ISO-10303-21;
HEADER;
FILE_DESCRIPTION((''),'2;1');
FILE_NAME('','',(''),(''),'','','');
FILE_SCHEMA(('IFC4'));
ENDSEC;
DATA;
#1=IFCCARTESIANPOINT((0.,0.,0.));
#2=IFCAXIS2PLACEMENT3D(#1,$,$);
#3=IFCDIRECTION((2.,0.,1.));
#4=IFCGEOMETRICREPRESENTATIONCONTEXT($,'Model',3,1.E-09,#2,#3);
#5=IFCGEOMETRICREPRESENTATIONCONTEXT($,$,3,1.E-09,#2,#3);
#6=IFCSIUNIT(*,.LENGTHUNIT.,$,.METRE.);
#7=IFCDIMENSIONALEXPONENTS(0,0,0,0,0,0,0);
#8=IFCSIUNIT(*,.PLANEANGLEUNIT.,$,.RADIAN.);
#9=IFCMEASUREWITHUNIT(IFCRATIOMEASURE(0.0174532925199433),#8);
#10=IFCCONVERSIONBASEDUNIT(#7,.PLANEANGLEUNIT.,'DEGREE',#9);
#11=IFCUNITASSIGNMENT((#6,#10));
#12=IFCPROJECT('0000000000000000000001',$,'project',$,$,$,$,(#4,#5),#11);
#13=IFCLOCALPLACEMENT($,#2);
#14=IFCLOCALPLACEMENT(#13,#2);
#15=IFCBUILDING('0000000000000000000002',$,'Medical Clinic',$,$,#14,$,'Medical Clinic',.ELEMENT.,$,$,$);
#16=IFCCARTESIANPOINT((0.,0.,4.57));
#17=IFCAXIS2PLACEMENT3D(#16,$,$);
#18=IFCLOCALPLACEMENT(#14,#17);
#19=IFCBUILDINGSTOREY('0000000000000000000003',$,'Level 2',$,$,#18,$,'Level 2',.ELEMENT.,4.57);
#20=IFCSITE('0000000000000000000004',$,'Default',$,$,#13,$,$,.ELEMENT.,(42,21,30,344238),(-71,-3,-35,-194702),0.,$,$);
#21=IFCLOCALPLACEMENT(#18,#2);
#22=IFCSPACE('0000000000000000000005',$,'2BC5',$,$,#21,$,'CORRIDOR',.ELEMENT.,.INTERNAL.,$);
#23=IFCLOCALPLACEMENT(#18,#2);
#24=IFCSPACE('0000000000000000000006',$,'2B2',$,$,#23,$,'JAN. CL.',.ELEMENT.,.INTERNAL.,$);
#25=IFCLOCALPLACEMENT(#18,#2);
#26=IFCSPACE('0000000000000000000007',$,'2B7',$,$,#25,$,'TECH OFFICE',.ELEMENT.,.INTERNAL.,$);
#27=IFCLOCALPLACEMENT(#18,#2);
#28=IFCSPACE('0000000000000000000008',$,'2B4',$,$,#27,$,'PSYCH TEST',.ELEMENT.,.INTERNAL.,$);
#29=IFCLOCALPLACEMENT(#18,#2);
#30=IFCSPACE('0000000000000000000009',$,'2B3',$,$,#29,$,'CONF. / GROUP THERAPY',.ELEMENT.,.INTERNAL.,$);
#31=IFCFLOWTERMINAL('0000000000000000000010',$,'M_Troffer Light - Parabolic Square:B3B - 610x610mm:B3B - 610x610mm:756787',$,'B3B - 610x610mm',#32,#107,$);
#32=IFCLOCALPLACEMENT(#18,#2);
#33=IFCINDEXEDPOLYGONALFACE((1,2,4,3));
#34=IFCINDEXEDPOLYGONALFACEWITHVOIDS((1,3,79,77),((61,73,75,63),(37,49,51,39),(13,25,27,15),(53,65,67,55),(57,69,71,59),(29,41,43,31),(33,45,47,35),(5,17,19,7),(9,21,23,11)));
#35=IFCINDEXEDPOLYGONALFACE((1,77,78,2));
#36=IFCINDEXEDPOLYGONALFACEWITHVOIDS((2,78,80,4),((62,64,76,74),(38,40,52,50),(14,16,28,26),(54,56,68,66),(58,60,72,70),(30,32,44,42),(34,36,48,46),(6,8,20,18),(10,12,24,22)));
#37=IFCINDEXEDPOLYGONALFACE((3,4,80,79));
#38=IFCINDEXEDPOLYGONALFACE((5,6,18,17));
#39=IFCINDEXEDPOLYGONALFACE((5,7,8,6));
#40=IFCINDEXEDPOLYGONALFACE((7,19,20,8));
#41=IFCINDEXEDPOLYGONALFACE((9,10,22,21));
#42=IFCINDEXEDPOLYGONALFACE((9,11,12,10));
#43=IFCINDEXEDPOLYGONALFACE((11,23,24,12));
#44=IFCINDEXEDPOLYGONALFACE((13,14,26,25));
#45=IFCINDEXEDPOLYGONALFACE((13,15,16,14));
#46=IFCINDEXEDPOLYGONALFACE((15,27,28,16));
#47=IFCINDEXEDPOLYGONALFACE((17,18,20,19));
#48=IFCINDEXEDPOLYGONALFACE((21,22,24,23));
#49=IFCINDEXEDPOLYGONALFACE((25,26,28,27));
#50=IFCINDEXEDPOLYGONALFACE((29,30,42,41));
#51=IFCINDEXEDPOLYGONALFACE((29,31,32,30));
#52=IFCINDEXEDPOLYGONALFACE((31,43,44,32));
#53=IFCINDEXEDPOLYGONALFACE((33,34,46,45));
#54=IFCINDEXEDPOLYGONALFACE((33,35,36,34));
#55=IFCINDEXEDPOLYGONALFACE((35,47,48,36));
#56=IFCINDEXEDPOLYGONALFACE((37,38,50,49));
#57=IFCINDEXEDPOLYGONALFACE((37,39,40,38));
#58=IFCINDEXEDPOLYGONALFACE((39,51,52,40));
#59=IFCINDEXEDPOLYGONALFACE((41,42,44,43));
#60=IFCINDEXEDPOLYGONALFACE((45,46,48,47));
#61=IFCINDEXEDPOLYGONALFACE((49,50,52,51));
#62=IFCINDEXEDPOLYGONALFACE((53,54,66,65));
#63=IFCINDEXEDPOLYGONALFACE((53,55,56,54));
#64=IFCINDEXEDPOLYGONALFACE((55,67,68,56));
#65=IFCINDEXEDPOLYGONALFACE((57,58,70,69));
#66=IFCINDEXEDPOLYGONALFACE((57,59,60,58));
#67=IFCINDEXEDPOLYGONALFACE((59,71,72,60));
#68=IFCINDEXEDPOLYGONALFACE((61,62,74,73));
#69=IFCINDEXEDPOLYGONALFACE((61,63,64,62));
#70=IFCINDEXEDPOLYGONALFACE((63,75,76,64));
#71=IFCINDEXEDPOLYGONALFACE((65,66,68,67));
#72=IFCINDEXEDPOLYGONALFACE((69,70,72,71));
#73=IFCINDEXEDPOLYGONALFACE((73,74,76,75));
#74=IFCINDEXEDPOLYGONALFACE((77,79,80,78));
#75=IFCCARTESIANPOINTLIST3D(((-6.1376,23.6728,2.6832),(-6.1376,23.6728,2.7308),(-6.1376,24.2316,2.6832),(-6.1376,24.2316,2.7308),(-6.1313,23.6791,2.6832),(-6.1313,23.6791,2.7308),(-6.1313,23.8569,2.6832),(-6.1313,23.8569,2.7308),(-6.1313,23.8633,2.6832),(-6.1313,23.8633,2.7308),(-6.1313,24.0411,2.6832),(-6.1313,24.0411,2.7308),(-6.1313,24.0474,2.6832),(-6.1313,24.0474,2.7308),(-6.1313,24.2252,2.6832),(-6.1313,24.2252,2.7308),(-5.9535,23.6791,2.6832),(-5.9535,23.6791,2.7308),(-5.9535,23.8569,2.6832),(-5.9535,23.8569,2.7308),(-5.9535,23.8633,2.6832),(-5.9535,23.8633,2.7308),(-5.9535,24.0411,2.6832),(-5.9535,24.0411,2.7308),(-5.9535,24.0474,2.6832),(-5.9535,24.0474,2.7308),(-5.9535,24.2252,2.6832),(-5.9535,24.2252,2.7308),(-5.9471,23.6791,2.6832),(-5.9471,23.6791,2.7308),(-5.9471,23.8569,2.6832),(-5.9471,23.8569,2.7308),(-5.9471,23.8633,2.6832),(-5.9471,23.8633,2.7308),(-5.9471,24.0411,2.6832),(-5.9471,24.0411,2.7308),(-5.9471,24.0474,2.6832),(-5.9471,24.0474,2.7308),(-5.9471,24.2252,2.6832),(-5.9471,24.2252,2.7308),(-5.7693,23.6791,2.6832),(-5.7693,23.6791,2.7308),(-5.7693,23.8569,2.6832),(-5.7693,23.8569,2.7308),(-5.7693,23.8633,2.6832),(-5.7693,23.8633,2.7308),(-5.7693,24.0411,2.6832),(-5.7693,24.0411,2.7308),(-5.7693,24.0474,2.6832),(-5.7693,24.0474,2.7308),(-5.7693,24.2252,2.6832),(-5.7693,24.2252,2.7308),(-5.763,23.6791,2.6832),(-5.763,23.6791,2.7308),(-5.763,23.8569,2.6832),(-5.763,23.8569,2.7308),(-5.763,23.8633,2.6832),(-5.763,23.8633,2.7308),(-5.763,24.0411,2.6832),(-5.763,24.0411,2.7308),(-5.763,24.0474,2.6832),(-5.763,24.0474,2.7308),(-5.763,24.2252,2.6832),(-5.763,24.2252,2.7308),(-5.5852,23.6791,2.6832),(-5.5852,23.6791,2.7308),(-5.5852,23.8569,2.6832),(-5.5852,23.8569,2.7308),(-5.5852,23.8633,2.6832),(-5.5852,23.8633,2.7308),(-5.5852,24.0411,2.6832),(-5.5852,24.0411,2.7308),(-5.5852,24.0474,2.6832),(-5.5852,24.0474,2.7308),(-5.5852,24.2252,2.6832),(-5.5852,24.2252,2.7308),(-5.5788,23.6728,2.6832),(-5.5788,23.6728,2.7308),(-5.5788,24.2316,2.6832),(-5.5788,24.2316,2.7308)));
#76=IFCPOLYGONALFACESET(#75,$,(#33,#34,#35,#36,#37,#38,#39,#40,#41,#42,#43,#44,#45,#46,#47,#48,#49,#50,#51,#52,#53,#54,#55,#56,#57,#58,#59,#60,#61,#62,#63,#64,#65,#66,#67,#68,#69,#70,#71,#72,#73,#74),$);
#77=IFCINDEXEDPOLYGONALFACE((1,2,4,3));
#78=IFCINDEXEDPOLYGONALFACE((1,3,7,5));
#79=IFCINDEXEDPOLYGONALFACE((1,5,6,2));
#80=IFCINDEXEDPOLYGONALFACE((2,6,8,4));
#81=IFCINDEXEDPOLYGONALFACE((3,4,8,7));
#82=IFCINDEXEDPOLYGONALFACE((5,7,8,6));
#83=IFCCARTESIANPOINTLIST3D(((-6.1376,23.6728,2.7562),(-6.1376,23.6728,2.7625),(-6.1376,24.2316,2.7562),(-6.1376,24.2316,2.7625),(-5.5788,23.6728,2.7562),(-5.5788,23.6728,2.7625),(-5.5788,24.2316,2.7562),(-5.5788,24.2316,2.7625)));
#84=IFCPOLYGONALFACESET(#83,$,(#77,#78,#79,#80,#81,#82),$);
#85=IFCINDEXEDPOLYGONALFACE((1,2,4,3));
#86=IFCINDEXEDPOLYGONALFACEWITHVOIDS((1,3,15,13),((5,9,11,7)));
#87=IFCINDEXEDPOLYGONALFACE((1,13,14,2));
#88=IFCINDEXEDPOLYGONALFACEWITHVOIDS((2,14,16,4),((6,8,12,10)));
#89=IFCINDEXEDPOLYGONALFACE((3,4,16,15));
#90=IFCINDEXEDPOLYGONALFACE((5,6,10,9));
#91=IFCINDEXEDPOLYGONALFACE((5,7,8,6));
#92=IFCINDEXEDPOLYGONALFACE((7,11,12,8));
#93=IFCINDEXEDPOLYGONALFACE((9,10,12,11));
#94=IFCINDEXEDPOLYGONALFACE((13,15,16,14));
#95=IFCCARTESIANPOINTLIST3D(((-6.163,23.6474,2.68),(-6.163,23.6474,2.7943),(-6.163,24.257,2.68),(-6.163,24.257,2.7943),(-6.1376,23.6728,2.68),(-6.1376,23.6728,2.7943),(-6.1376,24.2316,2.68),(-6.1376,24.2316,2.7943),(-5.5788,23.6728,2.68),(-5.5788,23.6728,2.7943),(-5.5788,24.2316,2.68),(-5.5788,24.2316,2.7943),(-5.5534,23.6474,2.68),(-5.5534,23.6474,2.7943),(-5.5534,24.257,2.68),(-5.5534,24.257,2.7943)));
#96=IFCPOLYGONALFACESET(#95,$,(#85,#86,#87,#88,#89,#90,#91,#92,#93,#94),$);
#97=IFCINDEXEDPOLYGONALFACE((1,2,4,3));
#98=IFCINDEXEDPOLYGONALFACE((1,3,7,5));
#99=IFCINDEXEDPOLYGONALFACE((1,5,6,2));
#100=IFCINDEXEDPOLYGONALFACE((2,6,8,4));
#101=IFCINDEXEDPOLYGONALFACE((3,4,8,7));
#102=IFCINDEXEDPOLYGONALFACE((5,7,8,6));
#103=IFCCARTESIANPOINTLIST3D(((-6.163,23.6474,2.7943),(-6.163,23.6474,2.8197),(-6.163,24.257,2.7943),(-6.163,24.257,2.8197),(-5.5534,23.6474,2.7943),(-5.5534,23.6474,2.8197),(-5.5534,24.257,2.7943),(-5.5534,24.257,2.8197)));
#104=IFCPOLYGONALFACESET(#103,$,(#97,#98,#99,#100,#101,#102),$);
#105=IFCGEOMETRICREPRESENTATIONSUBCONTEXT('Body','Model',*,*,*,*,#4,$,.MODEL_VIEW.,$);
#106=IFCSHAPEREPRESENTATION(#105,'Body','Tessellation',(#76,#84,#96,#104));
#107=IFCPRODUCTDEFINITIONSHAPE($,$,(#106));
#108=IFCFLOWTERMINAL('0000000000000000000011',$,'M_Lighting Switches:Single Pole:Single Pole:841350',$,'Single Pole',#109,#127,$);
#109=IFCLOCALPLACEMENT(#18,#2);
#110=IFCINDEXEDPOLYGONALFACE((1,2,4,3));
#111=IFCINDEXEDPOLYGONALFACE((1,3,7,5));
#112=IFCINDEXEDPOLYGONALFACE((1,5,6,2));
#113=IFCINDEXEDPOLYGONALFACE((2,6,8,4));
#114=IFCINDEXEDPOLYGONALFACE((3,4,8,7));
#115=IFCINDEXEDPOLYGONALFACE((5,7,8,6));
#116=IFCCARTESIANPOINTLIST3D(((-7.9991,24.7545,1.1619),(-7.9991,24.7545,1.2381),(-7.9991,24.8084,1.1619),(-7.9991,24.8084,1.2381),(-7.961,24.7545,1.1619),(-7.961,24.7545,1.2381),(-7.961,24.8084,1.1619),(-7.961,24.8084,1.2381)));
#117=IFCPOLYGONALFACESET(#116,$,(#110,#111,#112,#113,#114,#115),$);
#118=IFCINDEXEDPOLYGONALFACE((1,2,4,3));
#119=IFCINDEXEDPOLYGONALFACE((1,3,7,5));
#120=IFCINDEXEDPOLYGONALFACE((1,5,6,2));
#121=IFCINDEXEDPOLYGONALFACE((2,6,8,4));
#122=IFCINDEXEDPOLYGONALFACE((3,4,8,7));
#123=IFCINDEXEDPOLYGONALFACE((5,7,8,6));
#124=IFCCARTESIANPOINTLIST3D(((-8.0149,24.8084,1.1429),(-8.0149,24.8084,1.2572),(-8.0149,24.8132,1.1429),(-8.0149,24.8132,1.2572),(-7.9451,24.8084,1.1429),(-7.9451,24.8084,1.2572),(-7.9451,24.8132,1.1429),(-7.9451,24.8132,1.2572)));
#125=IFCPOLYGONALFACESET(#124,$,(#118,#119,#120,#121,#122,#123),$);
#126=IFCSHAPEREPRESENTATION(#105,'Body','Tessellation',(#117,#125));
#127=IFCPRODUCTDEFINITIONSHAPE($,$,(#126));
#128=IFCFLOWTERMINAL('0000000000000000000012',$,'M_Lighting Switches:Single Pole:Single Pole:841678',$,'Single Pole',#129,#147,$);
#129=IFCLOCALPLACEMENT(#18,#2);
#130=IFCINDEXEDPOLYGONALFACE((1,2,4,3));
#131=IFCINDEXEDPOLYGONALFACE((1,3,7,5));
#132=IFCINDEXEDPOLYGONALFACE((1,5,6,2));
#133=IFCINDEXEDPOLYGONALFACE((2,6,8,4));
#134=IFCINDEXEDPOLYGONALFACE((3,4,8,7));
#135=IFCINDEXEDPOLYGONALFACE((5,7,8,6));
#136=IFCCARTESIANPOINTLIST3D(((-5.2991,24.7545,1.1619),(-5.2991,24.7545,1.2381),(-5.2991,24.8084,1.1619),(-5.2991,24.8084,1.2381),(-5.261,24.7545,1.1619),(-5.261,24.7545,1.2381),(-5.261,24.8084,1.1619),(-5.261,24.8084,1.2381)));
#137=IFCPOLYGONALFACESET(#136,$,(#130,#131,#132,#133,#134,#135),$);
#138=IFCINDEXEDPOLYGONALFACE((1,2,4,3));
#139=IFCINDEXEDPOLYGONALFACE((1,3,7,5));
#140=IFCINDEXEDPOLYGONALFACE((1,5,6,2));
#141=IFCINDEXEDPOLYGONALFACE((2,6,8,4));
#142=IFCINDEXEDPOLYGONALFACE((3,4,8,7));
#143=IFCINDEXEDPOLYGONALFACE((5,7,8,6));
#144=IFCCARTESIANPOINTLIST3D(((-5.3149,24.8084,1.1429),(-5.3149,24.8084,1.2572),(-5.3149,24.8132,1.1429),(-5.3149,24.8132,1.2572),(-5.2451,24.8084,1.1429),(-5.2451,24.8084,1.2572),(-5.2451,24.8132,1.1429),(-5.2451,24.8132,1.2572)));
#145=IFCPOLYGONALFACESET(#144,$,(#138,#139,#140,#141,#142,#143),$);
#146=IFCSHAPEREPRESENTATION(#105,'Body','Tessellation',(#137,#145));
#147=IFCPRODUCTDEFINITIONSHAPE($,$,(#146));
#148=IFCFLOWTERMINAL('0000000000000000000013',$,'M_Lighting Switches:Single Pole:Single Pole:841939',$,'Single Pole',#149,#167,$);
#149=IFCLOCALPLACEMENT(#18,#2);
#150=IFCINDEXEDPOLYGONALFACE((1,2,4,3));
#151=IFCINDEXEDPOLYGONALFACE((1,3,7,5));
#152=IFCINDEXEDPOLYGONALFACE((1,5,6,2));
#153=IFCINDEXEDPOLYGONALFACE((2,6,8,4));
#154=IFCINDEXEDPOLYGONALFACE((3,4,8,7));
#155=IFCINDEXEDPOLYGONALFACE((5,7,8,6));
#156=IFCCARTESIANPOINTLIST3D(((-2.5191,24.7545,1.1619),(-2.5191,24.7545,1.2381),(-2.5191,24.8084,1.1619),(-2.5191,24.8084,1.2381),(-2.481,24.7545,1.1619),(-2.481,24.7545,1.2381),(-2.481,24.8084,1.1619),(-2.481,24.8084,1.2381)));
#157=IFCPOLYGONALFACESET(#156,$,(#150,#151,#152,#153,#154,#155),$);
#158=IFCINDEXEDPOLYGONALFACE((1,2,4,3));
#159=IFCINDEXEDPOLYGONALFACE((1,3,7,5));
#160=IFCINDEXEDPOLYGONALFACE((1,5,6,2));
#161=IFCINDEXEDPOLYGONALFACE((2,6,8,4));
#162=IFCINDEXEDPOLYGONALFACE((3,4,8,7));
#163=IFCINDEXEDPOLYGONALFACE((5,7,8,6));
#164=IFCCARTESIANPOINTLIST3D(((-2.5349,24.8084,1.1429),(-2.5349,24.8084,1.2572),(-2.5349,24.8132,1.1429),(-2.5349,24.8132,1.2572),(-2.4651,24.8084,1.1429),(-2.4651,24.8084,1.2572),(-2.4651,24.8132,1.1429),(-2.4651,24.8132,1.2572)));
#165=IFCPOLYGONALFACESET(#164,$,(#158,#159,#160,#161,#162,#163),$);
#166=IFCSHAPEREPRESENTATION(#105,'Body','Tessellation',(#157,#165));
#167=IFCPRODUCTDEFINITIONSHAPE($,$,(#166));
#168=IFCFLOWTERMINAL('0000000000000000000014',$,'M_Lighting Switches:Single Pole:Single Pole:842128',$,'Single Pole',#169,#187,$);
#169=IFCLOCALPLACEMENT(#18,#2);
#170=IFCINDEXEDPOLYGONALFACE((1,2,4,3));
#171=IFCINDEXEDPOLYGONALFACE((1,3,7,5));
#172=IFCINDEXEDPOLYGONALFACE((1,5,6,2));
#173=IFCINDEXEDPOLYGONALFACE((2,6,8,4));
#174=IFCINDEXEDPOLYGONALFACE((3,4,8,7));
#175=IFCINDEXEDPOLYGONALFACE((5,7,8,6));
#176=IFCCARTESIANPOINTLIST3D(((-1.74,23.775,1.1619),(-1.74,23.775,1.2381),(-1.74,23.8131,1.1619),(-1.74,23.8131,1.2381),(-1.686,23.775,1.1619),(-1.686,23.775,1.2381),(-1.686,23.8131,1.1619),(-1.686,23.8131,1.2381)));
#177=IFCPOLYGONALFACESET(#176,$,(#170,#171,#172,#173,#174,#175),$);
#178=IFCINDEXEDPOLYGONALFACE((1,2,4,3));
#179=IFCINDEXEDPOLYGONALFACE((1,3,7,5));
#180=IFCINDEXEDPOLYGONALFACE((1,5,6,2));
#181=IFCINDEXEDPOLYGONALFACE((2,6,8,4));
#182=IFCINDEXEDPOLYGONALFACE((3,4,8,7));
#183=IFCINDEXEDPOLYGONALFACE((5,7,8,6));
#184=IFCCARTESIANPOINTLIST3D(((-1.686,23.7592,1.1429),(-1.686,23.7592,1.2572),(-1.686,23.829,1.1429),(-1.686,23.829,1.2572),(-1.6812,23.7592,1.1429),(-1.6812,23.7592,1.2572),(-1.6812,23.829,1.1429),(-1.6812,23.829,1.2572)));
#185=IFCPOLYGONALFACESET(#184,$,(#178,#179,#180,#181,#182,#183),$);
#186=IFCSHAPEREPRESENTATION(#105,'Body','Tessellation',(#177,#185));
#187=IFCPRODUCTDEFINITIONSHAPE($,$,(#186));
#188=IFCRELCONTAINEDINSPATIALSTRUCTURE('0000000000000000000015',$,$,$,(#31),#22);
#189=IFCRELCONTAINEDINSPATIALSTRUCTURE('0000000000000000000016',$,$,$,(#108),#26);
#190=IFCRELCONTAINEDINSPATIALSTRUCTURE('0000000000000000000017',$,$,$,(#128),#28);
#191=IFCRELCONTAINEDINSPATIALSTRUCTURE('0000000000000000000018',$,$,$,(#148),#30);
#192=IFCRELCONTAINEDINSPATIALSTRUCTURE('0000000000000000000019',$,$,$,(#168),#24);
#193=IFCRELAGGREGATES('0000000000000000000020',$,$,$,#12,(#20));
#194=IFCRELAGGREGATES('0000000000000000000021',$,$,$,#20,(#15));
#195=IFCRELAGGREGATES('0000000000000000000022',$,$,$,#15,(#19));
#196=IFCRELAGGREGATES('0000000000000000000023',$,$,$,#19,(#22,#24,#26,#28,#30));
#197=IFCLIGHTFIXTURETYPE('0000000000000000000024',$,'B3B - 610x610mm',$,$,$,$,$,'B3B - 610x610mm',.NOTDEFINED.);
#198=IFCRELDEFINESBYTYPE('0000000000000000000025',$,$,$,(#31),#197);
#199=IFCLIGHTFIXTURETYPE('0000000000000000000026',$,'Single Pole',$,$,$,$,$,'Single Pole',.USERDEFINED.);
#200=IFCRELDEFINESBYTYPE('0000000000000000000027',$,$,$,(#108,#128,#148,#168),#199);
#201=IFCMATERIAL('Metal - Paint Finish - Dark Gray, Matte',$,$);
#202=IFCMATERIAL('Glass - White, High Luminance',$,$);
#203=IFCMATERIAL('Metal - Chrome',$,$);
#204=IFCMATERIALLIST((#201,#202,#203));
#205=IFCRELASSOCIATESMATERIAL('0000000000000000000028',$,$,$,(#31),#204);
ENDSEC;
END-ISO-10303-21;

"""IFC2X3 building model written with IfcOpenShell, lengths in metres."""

from ifc_helpers import new_model, entity, si_unit, converted_unit, direction, frame, frame_2d, origin, origin_2d_with_axis, place, context, subcontext, project, spatial, polyline, rectangle, outline, extrude, source, transform, mapped, material, material_list, type_object, type_shapes, element, save


model = new_model("IFC2X3")

# Units and contexts
model_context = context("Model", 3, precision=1e-09, world=origin(), true_north=direction((2.0, 0.0, 1.0)))
context_of_model = context(None, 3, precision=1e-09, world=origin(), true_north=direction((2.0, 0.0, 1.0)))
body_context = subcontext(model_context, "Body", "Model", "MODEL_VIEW")
ifc_project = project(units=[si_unit("LENGTHUNIT", "METRE"), converted_unit("PLANEANGLEUNIT", "DEGREE", entity("IfcRatioMeasure", 0.0174532925199433), si_unit("PLANEANGLEUNIT", "RADIAN"), dimensions=[0, 0, 0, 0, 0, 0, 0])], contexts=[model_context, context_of_model])

# Site, building, storey, space
site_placement = place(None, origin())
site = spatial("IfcSite", under=ifc_project, at=site_placement, Name="Default", CompositionType="ELEMENT", RefLatitude=(42, 21, 30, 344238), RefLongitude=(-71, -3, -35, -194702), RefElevation=0.0)
building_placement = place(site_placement, origin())
building = spatial("IfcBuilding", under=site, at=building_placement, Name="Medical Clinic", LongName="Medical Clinic", CompositionType="ELEMENT")
storey_placement = place(building_placement, frame((0.0, 0.0, 4.57)))
storey = spatial("IfcBuildingStorey", under=building, at=storey_placement, Name="Level 2", LongName="Level 2", CompositionType="ELEMENT", Elevation=4.57)
space_1_placement = place(storey_placement, origin())
space_1 = spatial("IfcSpace", under=storey, at=space_1_placement, Name="2BC5", LongName="CORRIDOR", CompositionType="ELEMENT", InteriorOrExteriorSpace="INTERNAL")

# Flow terminal
ifc_material_1 = material(Name="Metal - Paint Finish - Dark Gray, Matte")
ifc_material_2 = material(Name="Glass - White, High Luminance")
ifc_material_3 = material(Name="Metal - Chrome")
ifc_material_list_1 = material_list([ifc_material_1, ifc_material_2, ifc_material_3])
light_fixture_type_1 = type_object("IfcLightFixtureType", Name="B3B - 610x610mm", ElementType="B3B - 610x610mm", PredefinedType="NOTDEFINED")
shared_shape_1 = source(origin(), body_context, "Body", "SweptSolid", [
    extrude(outline(polyline([(-0.2794, -0.2794), (0.2794, -0.2794), (0.2794, 0.2794), (-0.2794, 0.2794), (-0.2794, -0.2794)]), holes=[polyline([(-0.0952, 0.0953), (-0.273, 0.0953), (-0.273, 0.2731), (-0.0952, 0.2731), (-0.0952, 0.0953)]), polyline([(0.2731, 0.0953), (0.0953, 0.0953), (0.0953, 0.2731), (0.2731, 0.2731), (0.2731, 0.0953)]), polyline([(-0.0889, 0.2731), (0.0889, 0.2731), (0.0889, 0.0953), (-0.0889, 0.0953), (-0.0889, 0.2731)]), polyline([(0.2731, -0.273), (0.0953, -0.273), (0.0953, -0.0952), (0.2731, -0.0952), (0.2731, -0.273)]), polyline([(0.0889, -0.273), (-0.0889, -0.273), (-0.0889, -0.0952), (0.0889, -0.0952), (0.0889, -0.273)]), polyline([(-0.0952, -0.273), (-0.273, -0.273), (-0.273, -0.0952), (-0.0952, -0.0952), (-0.0952, -0.273)]), polyline([(-0.0952, -0.0889), (-0.273, -0.0889), (-0.273, 0.0889), (-0.0952, 0.0889), (-0.0952, -0.0889)]), polyline([(0.0889, -0.0889), (-0.0889, -0.0889), (-0.0889, 0.0889), (0.0889, 0.0889), (0.0889, -0.0889)]), polyline([(0.2731, -0.0889), (0.0953, -0.0889), (0.0953, 0.0889), (0.2731, 0.0889), (0.2731, -0.0889)])]), frame((0.0, -0.3048, -0.0508), z_axis=(0.0, 0.0, 1.0), x_axis=(-1.0, 0.0, 0.0)), (0.0, 0.0, 1.0), 0.0476),
    extrude(rectangle(XDim=0.5588, YDim=0.5588, at=origin_2d_with_axis()), frame((0.0, -0.3048, -0.0825), z_axis=(0.0, 0.0, 1.0), x_axis=(-1.0, 0.0, 0.0)), (0.0, 0.0, 1.0), 0.0064),
    extrude(outline(polyline([(-0.3048, -0.3048), (0.3048, -0.3048), (0.3048, 0.3048), (-0.3048, 0.3048), (-0.3048, -0.3048)]), holes=[polyline([(0.2794, 0.2794), (0.2794, -0.2794), (-0.2794, -0.2794), (-0.2794, 0.2794), (0.2794, 0.2794)])]), frame((0.0, -0.3048, -0.1143)), (0.0, 0.0, 1.0), 0.1143),
    extrude(rectangle(XDim=0.6096, YDim=0.6096, at=origin_2d_with_axis()), frame((0.0, -0.3048, -0.1397), z_axis=(0.0, 0.0, 1.0), x_axis=(-1.0, 0.0, 0.0)), (0.0, 0.0, 1.0), 0.0254),
])
type_shapes(light_fixture_type_1, [shared_shape_1])
flow_terminal_1_placement = place(space_1_placement, frame((-5.8582, 23.6474, 2.68), z_axis=(0.0, 0.0, -1.0), x_axis=(1.0, 0.0, 0.0)))
element("IfcFlowTerminal", 1, at=flow_terminal_1_placement, inside=space_1, type_object=light_fixture_type_1, material=ifc_material_list_1, Name="M_Troffer Light - Parabolic Square:B3B - 610x610mm:B3B - 610x610mm:756787", ObjectType="B3B - 610x610mm", context=body_context, shape_type="MappedRepresentation", body=[
    mapped(shared_shape_1, transform((0.0, 0.0, 0.0), scale=1.0)),
])

# Shared definitions
space_2_placement = place(storey_placement, origin())
space_2 = spatial("IfcSpace", under=storey, at=space_2_placement, Name="2B2", LongName="JAN. CL.", CompositionType="ELEMENT", InteriorOrExteriorSpace="INTERNAL")

# Shared definitions
space_3_placement = place(storey_placement, origin())
space_3 = spatial("IfcSpace", under=storey, at=space_3_placement, Name="2B7", LongName="TECH OFFICE", CompositionType="ELEMENT", InteriorOrExteriorSpace="INTERNAL")

# Flow terminal
light_fixture_type_2 = type_object("IfcLightFixtureType", Name="Single Pole", ElementType="Single Pole", PredefinedType="USERDEFINED")
shared_shape_2 = source(origin(), body_context, "Body", "SweptSolid", [
    extrude(rectangle(XDim=0.0381, YDim=0.0762, at=origin_2d_with_axis()), frame((0.0, 0.0, -0.054), z_axis=(0.0, 0.0, 1.0), x_axis=(-1.0, 0.0, 0.0)), (0.0, 0.0, 1.0), 0.054),
    extrude(rectangle(XDim=0.0698, YDim=0.1143, at=frame_2d((0.0, 0.0), x_axis=(1.0, 0.0))), frame((0.0, 0.0, 0.0), z_axis=(0.0, 0.0, 1.0), x_axis=(-1.0, 0.0, 0.0)), (0.0, 0.0, 1.0), 0.0048),
])
type_shapes(light_fixture_type_2, [shared_shape_2])
flow_terminal_2_placement = place(space_3_placement, frame((-7.98, 24.8084, 1.2), z_axis=(0.0, 1.0, 0.0), x_axis=(-1.0, 0.0, 0.0)))
element("IfcFlowTerminal", 2, at=flow_terminal_2_placement, inside=space_3, type_object=light_fixture_type_2, Name="M_Lighting Switches:Single Pole:Single Pole:841350", ObjectType="Single Pole", context=body_context, shape_type="MappedRepresentation", body=[
    mapped(shared_shape_2, transform((0.0, 0.0, 0.0), scale=1.0)),
])

# Shared definitions
space_4_placement = place(storey_placement, origin())
space_4 = spatial("IfcSpace", under=storey, at=space_4_placement, Name="2B4", LongName="PSYCH TEST", CompositionType="ELEMENT", InteriorOrExteriorSpace="INTERNAL")

# Flow terminal
flow_terminal_3_placement = place(space_4_placement, frame((-5.28, 24.8084, 1.2), z_axis=(0.0, 1.0, 0.0), x_axis=(-1.0, 0.0, 0.0)))
element("IfcFlowTerminal", 3, at=flow_terminal_3_placement, inside=space_4, type_object=light_fixture_type_2, Name="M_Lighting Switches:Single Pole:Single Pole:841678", ObjectType="Single Pole", context=body_context, shape_type="MappedRepresentation", body=[
    mapped(shared_shape_2, transform((0.0, 0.0, 0.0), scale=1.0)),
])

# Shared definitions
space_5_placement = place(storey_placement, origin())
space_5 = spatial("IfcSpace", under=storey, at=space_5_placement, Name="2B3", LongName="CONF. / GROUP THERAPY", CompositionType="ELEMENT", InteriorOrExteriorSpace="INTERNAL")

# Flow terminals
flow_terminal_4_placement = place(space_5_placement, frame((-2.5, 24.8084, 1.2), z_axis=(0.0, 1.0, 0.0), x_axis=(-1.0, 0.0, 0.0)))
element("IfcFlowTerminal", 4, at=flow_terminal_4_placement, inside=space_5, type_object=light_fixture_type_2, Name="M_Lighting Switches:Single Pole:Single Pole:841939", ObjectType="Single Pole", context=body_context, shape_type="MappedRepresentation", body=[
    mapped(shared_shape_2, transform((0.0, 0.0, 0.0), scale=1.0)),
])
flow_terminal_5_placement = place(space_2_placement, frame((-1.686, 23.7941, 1.2), z_axis=(1.0, 0.0, 0.0), x_axis=(0.0, 1.0, 0.0)))
element("IfcFlowTerminal", 5, at=flow_terminal_5_placement, inside=space_2, type_object=light_fixture_type_2, Name="M_Lighting Switches:Single Pole:Single Pole:842128", ObjectType="Single Pole", context=body_context, shape_type="MappedRepresentation", body=[
    mapped(shared_shape_2, transform((0.0, 0.0, 0.0), scale=1.0)),
])

save(model, "model.ifc")
